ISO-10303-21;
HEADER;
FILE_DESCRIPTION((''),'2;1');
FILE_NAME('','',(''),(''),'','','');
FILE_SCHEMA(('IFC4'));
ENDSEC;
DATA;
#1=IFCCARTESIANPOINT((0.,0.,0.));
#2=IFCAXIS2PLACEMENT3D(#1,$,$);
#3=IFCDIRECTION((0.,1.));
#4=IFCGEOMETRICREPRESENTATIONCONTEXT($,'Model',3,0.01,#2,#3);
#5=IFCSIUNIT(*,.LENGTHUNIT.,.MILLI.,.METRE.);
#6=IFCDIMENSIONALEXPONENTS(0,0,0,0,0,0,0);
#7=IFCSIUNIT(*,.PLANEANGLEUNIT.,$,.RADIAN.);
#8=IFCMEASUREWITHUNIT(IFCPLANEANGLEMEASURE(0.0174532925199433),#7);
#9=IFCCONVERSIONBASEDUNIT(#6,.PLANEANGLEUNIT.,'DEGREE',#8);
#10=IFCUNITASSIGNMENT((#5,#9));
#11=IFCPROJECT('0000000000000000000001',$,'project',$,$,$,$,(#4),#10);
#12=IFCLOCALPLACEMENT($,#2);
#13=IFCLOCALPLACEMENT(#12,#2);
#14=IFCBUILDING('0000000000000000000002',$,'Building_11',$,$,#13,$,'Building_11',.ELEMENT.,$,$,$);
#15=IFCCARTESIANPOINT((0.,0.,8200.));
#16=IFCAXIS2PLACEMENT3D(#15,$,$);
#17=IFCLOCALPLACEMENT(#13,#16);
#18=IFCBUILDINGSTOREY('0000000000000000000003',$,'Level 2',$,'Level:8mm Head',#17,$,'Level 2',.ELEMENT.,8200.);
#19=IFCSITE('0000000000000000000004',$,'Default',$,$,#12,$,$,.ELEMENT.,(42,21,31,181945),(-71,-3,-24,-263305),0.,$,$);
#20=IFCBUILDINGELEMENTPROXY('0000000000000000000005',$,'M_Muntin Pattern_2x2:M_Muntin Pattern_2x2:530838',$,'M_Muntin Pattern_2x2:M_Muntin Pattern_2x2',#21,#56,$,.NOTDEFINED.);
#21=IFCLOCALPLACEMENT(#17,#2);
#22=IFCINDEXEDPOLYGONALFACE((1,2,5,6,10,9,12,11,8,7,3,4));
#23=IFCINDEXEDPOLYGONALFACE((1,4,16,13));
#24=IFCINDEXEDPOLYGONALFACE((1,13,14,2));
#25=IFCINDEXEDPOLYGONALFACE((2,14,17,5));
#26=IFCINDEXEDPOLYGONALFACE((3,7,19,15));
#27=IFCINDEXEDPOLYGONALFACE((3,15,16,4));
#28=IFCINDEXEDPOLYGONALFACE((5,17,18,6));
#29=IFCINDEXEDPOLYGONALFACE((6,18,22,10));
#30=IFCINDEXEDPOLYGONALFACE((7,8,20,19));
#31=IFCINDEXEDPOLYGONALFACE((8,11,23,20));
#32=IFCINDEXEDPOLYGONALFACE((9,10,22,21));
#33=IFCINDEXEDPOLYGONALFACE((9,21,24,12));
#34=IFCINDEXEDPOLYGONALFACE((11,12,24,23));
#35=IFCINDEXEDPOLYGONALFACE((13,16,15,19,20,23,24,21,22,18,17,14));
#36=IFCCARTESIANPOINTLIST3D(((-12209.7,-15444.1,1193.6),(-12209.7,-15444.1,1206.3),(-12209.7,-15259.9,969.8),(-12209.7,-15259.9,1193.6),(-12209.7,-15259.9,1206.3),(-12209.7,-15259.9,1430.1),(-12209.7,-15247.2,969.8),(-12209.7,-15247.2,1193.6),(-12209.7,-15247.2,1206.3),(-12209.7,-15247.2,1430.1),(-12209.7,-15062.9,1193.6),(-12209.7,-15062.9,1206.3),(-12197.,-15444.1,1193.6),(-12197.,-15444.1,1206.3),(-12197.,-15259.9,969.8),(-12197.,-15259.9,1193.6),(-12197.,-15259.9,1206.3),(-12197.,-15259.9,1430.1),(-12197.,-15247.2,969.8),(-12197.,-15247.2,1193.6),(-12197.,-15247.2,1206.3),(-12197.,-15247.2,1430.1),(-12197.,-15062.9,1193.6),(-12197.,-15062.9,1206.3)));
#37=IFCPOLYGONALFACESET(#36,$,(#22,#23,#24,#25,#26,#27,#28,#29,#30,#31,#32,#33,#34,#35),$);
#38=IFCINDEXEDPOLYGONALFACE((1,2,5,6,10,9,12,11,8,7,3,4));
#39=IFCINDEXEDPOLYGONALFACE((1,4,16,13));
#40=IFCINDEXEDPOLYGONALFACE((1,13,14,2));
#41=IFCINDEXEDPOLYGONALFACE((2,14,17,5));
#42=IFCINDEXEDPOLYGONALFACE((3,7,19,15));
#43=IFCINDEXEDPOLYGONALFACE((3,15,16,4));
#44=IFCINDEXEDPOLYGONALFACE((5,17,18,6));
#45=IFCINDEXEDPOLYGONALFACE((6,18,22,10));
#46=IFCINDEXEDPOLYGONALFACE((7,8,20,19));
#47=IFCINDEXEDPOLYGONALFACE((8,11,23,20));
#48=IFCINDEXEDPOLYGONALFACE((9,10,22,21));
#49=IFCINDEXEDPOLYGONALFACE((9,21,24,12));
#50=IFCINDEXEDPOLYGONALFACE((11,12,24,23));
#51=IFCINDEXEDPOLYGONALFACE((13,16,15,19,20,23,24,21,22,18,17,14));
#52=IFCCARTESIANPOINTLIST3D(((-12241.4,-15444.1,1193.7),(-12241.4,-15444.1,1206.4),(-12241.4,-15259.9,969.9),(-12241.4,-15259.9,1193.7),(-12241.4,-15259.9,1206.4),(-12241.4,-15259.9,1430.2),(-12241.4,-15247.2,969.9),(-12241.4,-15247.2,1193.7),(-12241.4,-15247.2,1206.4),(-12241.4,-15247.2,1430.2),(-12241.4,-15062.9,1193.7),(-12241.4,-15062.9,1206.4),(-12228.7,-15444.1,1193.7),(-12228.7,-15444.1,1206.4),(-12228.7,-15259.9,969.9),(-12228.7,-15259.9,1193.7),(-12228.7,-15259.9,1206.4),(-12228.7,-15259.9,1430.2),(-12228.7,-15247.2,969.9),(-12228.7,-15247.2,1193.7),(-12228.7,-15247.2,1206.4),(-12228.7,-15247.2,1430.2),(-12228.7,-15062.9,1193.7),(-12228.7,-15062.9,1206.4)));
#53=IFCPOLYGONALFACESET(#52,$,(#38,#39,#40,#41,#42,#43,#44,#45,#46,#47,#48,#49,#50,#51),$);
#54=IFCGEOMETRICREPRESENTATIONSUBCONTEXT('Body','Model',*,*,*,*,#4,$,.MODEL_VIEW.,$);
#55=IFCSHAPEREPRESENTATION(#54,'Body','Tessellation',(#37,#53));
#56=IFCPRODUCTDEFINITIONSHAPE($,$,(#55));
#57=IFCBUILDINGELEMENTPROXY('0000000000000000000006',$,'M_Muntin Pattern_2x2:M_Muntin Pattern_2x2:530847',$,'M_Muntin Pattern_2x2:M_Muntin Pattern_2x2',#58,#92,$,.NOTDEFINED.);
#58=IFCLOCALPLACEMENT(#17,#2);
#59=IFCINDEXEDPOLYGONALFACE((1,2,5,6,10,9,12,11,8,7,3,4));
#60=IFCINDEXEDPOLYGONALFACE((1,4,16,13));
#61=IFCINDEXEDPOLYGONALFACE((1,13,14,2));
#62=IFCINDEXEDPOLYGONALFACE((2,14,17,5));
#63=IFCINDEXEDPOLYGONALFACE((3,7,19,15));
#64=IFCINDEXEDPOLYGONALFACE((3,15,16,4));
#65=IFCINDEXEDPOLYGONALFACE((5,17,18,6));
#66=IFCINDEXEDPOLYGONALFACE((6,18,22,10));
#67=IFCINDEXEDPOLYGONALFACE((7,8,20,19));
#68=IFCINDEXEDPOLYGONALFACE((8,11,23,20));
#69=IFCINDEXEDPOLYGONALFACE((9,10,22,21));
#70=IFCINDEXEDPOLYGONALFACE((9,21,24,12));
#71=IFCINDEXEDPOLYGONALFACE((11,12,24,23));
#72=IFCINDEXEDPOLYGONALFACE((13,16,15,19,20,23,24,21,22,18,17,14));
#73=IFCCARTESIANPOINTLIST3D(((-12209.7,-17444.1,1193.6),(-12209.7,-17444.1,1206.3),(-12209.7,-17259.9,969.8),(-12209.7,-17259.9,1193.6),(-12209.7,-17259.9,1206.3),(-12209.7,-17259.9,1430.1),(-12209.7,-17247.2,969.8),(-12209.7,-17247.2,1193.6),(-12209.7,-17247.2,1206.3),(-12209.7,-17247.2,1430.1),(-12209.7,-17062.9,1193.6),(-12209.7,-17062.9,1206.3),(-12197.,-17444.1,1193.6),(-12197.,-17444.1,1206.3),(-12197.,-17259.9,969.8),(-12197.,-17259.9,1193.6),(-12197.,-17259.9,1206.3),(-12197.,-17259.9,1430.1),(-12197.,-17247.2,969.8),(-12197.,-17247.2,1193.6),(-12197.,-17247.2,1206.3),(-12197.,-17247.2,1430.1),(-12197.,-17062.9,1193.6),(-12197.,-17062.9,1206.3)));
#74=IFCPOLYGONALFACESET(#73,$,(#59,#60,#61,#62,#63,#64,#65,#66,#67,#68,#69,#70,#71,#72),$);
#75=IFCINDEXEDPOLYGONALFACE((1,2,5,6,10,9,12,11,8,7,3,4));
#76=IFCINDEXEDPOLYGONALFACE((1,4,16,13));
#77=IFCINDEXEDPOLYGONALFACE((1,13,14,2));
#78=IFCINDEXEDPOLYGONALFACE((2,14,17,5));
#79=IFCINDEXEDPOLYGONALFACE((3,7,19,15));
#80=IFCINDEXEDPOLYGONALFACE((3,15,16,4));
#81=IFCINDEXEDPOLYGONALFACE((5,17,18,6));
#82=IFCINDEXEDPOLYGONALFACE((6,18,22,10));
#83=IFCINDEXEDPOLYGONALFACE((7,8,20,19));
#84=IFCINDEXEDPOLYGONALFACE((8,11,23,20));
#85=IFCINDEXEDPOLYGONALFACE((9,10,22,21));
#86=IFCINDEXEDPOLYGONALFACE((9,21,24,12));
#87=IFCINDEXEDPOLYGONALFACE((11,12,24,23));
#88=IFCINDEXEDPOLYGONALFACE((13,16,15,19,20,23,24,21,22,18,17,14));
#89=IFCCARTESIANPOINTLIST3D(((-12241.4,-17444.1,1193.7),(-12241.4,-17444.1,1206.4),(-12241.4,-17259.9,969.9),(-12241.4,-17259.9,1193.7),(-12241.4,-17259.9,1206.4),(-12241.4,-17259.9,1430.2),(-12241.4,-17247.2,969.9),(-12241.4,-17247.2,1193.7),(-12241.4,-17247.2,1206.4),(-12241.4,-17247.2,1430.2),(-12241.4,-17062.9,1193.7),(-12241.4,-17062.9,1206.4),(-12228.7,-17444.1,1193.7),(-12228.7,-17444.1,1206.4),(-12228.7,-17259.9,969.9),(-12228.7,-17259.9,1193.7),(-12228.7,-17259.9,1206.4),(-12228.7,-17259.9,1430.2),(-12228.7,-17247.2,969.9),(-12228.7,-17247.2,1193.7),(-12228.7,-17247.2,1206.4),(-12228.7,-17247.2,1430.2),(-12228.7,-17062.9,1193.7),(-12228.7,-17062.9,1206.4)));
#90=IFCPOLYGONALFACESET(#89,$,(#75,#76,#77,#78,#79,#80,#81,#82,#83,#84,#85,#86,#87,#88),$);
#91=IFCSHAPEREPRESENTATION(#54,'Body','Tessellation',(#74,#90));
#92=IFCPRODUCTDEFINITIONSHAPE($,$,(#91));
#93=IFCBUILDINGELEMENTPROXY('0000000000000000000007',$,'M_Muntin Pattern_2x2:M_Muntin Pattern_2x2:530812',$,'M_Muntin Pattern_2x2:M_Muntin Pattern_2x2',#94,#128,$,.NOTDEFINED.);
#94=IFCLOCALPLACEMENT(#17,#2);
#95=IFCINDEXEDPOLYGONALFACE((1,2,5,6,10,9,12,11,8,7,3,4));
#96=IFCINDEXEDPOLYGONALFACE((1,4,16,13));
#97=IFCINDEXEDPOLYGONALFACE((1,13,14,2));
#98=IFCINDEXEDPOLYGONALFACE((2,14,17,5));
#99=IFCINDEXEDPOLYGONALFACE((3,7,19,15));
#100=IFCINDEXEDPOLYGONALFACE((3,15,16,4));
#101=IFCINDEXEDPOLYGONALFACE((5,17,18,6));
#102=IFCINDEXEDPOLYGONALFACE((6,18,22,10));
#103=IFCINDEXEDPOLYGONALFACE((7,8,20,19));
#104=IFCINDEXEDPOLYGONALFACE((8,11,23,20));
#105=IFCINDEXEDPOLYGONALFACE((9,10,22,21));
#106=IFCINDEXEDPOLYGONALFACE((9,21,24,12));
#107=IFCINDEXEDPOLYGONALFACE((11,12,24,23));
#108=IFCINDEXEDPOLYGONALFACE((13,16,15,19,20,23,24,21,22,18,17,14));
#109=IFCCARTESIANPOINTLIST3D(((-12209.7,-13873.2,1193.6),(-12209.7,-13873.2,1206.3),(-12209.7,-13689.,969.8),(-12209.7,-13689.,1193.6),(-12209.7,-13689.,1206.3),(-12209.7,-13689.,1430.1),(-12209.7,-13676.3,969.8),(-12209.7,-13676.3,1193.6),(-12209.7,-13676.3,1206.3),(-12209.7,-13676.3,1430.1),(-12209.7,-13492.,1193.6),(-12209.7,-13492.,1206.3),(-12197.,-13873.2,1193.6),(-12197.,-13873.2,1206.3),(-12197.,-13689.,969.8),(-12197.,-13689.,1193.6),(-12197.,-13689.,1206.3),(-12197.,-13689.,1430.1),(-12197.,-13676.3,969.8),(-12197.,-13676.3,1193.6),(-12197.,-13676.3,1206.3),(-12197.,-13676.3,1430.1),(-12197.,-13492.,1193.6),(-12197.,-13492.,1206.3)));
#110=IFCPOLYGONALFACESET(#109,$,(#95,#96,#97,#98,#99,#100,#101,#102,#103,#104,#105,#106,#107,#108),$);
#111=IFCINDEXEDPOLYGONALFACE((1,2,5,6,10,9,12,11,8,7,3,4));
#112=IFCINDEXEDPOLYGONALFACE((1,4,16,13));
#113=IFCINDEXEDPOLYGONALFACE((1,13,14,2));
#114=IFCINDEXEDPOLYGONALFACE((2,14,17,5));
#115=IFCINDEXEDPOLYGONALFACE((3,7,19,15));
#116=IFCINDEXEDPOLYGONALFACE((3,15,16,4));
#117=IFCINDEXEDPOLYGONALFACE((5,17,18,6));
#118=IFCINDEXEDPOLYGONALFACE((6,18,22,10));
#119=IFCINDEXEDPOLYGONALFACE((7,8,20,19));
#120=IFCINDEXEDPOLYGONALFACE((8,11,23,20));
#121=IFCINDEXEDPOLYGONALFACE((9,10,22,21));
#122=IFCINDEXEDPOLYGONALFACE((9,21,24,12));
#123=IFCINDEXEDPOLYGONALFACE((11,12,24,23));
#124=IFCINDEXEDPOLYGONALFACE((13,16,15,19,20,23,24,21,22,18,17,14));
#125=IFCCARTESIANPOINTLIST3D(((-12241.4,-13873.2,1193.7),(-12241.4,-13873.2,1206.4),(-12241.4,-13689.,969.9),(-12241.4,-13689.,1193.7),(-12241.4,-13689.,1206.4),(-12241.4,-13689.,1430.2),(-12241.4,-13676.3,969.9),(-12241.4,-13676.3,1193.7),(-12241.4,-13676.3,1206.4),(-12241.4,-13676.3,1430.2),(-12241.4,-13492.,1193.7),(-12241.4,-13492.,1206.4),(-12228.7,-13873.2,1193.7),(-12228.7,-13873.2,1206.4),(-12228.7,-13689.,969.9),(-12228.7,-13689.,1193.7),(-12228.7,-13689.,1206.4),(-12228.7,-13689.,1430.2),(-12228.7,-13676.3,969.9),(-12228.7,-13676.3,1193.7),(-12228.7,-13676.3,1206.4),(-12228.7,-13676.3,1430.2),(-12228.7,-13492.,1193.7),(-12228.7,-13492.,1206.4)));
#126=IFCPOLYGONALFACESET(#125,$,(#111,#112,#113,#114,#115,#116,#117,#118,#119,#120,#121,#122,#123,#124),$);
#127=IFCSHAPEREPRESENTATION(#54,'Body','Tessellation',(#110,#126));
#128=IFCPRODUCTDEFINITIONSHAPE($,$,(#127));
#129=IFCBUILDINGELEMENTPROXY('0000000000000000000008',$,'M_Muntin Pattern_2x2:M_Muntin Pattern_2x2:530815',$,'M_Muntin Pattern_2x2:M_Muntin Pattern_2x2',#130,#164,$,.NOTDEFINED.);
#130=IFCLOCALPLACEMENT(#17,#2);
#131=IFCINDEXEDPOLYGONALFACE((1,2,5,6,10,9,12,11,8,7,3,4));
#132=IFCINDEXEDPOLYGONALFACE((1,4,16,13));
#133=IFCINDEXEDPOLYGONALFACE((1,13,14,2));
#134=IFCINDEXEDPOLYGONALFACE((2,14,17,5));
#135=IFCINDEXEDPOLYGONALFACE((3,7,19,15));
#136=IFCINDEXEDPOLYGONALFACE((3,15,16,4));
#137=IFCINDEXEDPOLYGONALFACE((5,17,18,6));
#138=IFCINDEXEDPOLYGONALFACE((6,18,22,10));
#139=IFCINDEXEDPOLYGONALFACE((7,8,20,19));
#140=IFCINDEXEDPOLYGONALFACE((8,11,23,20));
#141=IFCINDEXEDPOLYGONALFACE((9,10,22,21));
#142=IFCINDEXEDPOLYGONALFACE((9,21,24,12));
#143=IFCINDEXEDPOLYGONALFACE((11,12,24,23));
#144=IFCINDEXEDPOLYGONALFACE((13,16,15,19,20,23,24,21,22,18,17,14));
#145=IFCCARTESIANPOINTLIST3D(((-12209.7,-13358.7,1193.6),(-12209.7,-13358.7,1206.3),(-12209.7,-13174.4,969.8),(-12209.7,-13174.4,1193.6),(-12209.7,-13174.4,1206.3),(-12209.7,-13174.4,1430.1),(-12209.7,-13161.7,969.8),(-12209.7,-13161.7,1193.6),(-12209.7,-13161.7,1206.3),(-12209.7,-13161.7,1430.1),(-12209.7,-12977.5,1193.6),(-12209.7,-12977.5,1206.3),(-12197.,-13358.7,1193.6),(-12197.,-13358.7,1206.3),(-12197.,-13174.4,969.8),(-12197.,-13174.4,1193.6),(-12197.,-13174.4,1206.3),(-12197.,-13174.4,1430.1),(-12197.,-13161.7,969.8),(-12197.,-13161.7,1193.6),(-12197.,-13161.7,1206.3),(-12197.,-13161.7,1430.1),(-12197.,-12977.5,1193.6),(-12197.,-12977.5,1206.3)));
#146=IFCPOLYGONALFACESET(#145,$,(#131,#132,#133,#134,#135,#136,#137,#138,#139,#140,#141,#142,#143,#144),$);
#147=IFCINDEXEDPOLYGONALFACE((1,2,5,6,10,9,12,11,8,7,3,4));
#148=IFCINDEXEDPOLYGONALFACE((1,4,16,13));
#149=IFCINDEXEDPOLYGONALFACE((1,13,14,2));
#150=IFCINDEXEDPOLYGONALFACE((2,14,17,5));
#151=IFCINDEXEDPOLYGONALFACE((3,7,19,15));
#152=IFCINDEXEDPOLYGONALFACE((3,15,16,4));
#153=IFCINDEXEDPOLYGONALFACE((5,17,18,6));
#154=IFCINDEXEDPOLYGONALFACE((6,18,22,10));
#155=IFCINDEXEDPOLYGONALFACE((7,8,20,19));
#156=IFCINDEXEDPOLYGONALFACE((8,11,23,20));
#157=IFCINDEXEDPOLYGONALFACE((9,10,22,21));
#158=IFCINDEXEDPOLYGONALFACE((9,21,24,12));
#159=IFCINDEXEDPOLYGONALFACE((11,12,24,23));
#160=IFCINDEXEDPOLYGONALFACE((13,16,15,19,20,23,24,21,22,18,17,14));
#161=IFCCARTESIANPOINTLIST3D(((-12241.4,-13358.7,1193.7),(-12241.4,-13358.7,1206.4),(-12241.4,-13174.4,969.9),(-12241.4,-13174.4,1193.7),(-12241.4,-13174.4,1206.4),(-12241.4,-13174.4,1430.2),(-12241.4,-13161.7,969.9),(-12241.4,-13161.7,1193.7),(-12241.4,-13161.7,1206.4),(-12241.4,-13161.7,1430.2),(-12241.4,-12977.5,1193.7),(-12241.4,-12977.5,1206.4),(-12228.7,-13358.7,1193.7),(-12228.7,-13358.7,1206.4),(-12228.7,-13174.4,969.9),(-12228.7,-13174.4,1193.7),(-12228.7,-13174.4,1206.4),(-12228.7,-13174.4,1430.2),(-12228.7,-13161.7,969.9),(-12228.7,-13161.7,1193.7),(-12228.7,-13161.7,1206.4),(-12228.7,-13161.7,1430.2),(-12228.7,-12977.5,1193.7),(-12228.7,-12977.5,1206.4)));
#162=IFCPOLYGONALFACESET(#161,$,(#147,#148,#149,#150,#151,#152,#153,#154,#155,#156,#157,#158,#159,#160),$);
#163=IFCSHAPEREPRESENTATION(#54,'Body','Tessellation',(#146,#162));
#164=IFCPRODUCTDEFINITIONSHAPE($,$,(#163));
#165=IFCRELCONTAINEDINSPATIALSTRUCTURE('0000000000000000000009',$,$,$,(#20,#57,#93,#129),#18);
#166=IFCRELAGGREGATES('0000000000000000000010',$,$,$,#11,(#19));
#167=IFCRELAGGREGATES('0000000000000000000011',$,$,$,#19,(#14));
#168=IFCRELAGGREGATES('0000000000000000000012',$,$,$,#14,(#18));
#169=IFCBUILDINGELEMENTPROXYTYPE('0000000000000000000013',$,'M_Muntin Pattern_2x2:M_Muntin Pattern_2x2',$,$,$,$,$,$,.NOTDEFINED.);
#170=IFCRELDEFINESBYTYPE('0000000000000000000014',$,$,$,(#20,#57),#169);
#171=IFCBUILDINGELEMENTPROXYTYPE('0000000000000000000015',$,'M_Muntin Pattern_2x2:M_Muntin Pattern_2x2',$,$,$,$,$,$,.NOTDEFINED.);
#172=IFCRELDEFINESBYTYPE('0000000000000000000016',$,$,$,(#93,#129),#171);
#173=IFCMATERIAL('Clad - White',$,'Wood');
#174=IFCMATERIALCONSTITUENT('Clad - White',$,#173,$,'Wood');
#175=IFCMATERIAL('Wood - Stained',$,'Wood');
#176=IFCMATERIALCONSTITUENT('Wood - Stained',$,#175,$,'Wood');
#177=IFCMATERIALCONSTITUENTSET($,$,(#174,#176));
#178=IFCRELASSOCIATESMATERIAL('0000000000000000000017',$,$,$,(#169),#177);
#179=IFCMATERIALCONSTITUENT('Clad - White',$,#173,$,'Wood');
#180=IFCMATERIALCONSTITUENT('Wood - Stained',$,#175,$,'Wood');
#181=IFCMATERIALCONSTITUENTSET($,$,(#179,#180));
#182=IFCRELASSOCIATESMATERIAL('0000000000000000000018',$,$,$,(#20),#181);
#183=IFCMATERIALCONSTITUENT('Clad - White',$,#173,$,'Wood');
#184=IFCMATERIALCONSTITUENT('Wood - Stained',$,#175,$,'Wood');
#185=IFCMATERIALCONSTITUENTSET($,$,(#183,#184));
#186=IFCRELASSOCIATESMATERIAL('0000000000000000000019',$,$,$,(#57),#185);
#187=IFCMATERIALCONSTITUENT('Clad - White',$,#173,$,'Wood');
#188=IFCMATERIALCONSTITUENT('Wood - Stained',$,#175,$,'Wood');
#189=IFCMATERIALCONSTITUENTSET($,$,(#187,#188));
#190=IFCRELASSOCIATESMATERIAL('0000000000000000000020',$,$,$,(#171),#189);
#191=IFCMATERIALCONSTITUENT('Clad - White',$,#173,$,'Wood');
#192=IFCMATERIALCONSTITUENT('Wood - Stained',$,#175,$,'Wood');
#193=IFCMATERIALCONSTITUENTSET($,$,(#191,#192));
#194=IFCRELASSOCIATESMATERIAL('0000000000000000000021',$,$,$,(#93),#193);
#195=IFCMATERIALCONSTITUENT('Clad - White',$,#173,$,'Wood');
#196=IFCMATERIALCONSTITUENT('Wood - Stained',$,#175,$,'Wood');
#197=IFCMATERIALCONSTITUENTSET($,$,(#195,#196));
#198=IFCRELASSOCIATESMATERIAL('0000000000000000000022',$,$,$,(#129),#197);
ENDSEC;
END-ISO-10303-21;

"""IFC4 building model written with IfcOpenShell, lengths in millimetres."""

from ifc_helpers import new_model, entity, si_unit, converted_unit, direction, frame, origin, place, context, subcontext, project, spatial, indexed_curve, outline, extrude, source, transform, mapped, material, constituent, constituent_set, type_object, type_shapes, element, save


model = new_model("IFC4")

# Units and contexts
model_context = context("Model", 3, precision=0.01, world=origin(), true_north=direction((0.0, 1.0)))
body_context = subcontext(model_context, "Body", "Model", "MODEL_VIEW")
ifc_project = project(units=[si_unit("LENGTHUNIT", "METRE", prefix="MILLI"), converted_unit("PLANEANGLEUNIT", "DEGREE", entity("IfcPlaneAngleMeasure", 0.0174532925199433), si_unit("PLANEANGLEUNIT", "RADIAN"), dimensions=[0, 0, 0, 0, 0, 0, 0])], contexts=[model_context])

# Site, building, storey
site_placement = place(None, origin())
site = spatial("IfcSite", under=ifc_project, at=site_placement, Name="Default", CompositionType="ELEMENT", RefLatitude=(42, 21, 31, 181945), RefLongitude=(-71, -3, -24, -263305), RefElevation=0.0)
building_placement = place(site_placement, origin())
building = spatial("IfcBuilding", under=site, at=building_placement, Name="Building_11", LongName="Building_11", CompositionType="ELEMENT")
storey_placement = place(building_placement, frame((0.0, 0.0, 8200.0)))
storey = spatial("IfcBuildingStorey", under=building, at=storey_placement, Name="Level 2", ObjectType="Level:8mm Head", LongName="Level 2", CompositionType="ELEMENT", Elevation=8200.0)

# Building element proxies
ifc_material_1 = material(Name="Clad - White", Category="Wood")
ifc_material_2 = material(Name="Wood - Stained", Category="Wood")
ifc_constituent_1 = constituent(ifc_material_1, Name="Clad - White", Category="Wood")
ifc_constituent_2 = constituent(ifc_material_2, Name="Wood - Stained", Category="Wood")
ifc_constituent_set_1 = constituent_set(constituents=[ifc_constituent_1, ifc_constituent_2])
building_element_proxy_type_1 = type_object("IfcBuildingElementProxyType", Name="M_Muntin Pattern_2x2:M_Muntin Pattern_2x2", PredefinedType="NOTDEFINED", material=ifc_constituent_set_1)
shared_shape_1 = source(origin(), body_context, "Body", "SweptSolid", [
    extrude(outline(indexed_curve([(6.4, -6.4), (230.1, -6.4), (230.1, 6.3), (6.4, 6.3), (6.4, 190.6), (-6.3, 190.6), (-6.3, 6.3), (-230.2, 6.3), (-230.2, -6.4), (-6.3, -6.4), (-6.3, -190.6), (6.4, -190.6), (6.4, -6.4)], self_intersect=False)), frame((0.0, 9.5, 230.1), z_axis=(0.0, 1.0, 0.0), x_axis=(0.0, 0.0, 1.0)), (0.0, 0.0, 1.0), 12.7),
    extrude(outline(indexed_curve([(6.4, -6.4), (230.2, -6.4), (230.2, 6.3), (6.4, 6.3), (6.4, 190.6), (-6.3, 190.6), (-6.3, 6.3), (-230.2, 6.3), (-230.2, -6.4), (-6.3, -6.4), (-6.3, -190.6), (6.4, -190.6), (6.4, -6.4)], self_intersect=False)), frame((0.0, -22.2, 230.2), z_axis=(0.0, 1.0, 0.0), x_axis=(0.0, 0.0, 1.0)), (0.0, 0.0, 1.0), 12.7),
])
type_shapes(building_element_proxy_type_1, [shared_shape_1])
ifc_constituent_3 = constituent(ifc_material_1, Name="Clad - White", Category="Wood")
ifc_constituent_4 = constituent(ifc_material_2, Name="Wood - Stained", Category="Wood")
ifc_constituent_set_2 = constituent_set(constituents=[ifc_constituent_3, ifc_constituent_4])
proxy_1_placement = place(storey_placement, frame((-12219.2, -15253.5, 969.9), z_axis=(0.0, 0.0, 1.0), x_axis=(0.0, -1.0, 0.0)))
element("IfcBuildingElementProxy", 1, at=proxy_1_placement, inside=storey, type_object=building_element_proxy_type_1, material=ifc_constituent_set_2, Name="M_Muntin Pattern_2x2:M_Muntin Pattern_2x2:530838", ObjectType="M_Muntin Pattern_2x2:M_Muntin Pattern_2x2", PredefinedType="NOTDEFINED", context=body_context, shape_type="MappedRepresentation", body=[
    mapped(shared_shape_1, transform((0.0, 0.0, 0.0), scale=1.0)),
])
ifc_constituent_5 = constituent(ifc_material_1, Name="Clad - White", Category="Wood")
ifc_constituent_6 = constituent(ifc_material_2, Name="Wood - Stained", Category="Wood")
ifc_constituent_set_3 = constituent_set(constituents=[ifc_constituent_5, ifc_constituent_6])
proxy_2_placement = place(storey_placement, frame((-12219.2, -17253.5, 969.9), z_axis=(0.0, 0.0, 1.0), x_axis=(0.0, -1.0, 0.0)))
element("IfcBuildingElementProxy", 2, at=proxy_2_placement, inside=storey, type_object=building_element_proxy_type_1, material=ifc_constituent_set_3, Name="M_Muntin Pattern_2x2:M_Muntin Pattern_2x2:530847", ObjectType="M_Muntin Pattern_2x2:M_Muntin Pattern_2x2", PredefinedType="NOTDEFINED", context=body_context, shape_type="MappedRepresentation", body=[
    mapped(shared_shape_1, transform((0.0, 0.0, 0.0), scale=1.0)),
])
ifc_constituent_7 = constituent(ifc_material_1, Name="Clad - White", Category="Wood")
ifc_constituent_8 = constituent(ifc_material_2, Name="Wood - Stained", Category="Wood")
ifc_constituent_set_4 = constituent_set(constituents=[ifc_constituent_7, ifc_constituent_8])
ifc_constituent_9 = constituent(ifc_material_1, Name="Clad - White", Category="Wood")
ifc_constituent_10 = constituent(ifc_material_2, Name="Wood - Stained", Category="Wood")
ifc_constituent_set_5 = constituent_set(constituents=[ifc_constituent_9, ifc_constituent_10])
building_element_proxy_type_2 = type_object("IfcBuildingElementProxyType", Name="M_Muntin Pattern_2x2:M_Muntin Pattern_2x2", PredefinedType="NOTDEFINED", material=ifc_constituent_set_5)
shared_shape_2 = source(origin(), body_context, "Body", "SweptSolid", [
    extrude(outline(indexed_curve([(6.4, -6.4), (230.1, -6.4), (230.1, 6.3), (6.4, 6.3), (6.4, 190.6), (-6.3, 190.6), (-6.3, 6.3), (-230.2, 6.3), (-230.2, -6.4), (-6.3, -6.4), (-6.3, -190.6), (6.4, -190.6), (6.4, -6.4)], self_intersect=False)), frame((0.0, -22.2, 230.1), z_axis=(0.0, 1.0, 0.0), x_axis=(0.0, 0.0, 1.0)), (0.0, 0.0, 1.0), 12.7),
    extrude(outline(indexed_curve([(6.4, -6.4), (230.2, -6.4), (230.2, 6.3), (6.4, 6.3), (6.4, 190.6), (-6.3, 190.6), (-6.3, 6.3), (-230.2, 6.3), (-230.2, -6.4), (-6.3, -6.4), (-6.3, -190.6), (6.4, -190.6), (6.4, -6.4)], self_intersect=False)), frame((0.0, 9.5, 230.2), z_axis=(0.0, 1.0, 0.0), x_axis=(0.0, 0.0, 1.0)), (0.0, 0.0, 1.0), 12.7),
])
type_shapes(building_element_proxy_type_2, [shared_shape_2])
proxy_3_placement = place(storey_placement, frame((-12219.2, -13682.6, 969.9), z_axis=(0.0, 0.0, 1.0), x_axis=(0.0, 1.0, 0.0)))
element("IfcBuildingElementProxy", 3, at=proxy_3_placement, inside=storey, type_object=building_element_proxy_type_2, material=ifc_constituent_set_4, Name="M_Muntin Pattern_2x2:M_Muntin Pattern_2x2:530812", ObjectType="M_Muntin Pattern_2x2:M_Muntin Pattern_2x2", PredefinedType="NOTDEFINED", context=body_context, shape_type="MappedRepresentation", body=[
    mapped(shared_shape_2, transform((0.0, 0.0, 0.0), scale=1.0)),
])
ifc_constituent_11 = constituent(ifc_material_1, Name="Clad - White", Category="Wood")
ifc_constituent_12 = constituent(ifc_material_2, Name="Wood - Stained", Category="Wood")
ifc_constituent_set_6 = constituent_set(constituents=[ifc_constituent_11, ifc_constituent_12])
proxy_4_placement = place(storey_placement, frame((-12219.2, -13168.1, 969.9), z_axis=(0.0, 0.0, 1.0), x_axis=(0.0, 1.0, 0.0)))
element("IfcBuildingElementProxy", 4, at=proxy_4_placement, inside=storey, type_object=building_element_proxy_type_2, material=ifc_constituent_set_6, Name="M_Muntin Pattern_2x2:M_Muntin Pattern_2x2:530815", ObjectType="M_Muntin Pattern_2x2:M_Muntin Pattern_2x2", PredefinedType="NOTDEFINED", context=body_context, shape_type="MappedRepresentation", body=[
    mapped(shared_shape_2, transform((0.0, 0.0, 0.0), scale=1.0)),
])

save(model, "model.ifc")
